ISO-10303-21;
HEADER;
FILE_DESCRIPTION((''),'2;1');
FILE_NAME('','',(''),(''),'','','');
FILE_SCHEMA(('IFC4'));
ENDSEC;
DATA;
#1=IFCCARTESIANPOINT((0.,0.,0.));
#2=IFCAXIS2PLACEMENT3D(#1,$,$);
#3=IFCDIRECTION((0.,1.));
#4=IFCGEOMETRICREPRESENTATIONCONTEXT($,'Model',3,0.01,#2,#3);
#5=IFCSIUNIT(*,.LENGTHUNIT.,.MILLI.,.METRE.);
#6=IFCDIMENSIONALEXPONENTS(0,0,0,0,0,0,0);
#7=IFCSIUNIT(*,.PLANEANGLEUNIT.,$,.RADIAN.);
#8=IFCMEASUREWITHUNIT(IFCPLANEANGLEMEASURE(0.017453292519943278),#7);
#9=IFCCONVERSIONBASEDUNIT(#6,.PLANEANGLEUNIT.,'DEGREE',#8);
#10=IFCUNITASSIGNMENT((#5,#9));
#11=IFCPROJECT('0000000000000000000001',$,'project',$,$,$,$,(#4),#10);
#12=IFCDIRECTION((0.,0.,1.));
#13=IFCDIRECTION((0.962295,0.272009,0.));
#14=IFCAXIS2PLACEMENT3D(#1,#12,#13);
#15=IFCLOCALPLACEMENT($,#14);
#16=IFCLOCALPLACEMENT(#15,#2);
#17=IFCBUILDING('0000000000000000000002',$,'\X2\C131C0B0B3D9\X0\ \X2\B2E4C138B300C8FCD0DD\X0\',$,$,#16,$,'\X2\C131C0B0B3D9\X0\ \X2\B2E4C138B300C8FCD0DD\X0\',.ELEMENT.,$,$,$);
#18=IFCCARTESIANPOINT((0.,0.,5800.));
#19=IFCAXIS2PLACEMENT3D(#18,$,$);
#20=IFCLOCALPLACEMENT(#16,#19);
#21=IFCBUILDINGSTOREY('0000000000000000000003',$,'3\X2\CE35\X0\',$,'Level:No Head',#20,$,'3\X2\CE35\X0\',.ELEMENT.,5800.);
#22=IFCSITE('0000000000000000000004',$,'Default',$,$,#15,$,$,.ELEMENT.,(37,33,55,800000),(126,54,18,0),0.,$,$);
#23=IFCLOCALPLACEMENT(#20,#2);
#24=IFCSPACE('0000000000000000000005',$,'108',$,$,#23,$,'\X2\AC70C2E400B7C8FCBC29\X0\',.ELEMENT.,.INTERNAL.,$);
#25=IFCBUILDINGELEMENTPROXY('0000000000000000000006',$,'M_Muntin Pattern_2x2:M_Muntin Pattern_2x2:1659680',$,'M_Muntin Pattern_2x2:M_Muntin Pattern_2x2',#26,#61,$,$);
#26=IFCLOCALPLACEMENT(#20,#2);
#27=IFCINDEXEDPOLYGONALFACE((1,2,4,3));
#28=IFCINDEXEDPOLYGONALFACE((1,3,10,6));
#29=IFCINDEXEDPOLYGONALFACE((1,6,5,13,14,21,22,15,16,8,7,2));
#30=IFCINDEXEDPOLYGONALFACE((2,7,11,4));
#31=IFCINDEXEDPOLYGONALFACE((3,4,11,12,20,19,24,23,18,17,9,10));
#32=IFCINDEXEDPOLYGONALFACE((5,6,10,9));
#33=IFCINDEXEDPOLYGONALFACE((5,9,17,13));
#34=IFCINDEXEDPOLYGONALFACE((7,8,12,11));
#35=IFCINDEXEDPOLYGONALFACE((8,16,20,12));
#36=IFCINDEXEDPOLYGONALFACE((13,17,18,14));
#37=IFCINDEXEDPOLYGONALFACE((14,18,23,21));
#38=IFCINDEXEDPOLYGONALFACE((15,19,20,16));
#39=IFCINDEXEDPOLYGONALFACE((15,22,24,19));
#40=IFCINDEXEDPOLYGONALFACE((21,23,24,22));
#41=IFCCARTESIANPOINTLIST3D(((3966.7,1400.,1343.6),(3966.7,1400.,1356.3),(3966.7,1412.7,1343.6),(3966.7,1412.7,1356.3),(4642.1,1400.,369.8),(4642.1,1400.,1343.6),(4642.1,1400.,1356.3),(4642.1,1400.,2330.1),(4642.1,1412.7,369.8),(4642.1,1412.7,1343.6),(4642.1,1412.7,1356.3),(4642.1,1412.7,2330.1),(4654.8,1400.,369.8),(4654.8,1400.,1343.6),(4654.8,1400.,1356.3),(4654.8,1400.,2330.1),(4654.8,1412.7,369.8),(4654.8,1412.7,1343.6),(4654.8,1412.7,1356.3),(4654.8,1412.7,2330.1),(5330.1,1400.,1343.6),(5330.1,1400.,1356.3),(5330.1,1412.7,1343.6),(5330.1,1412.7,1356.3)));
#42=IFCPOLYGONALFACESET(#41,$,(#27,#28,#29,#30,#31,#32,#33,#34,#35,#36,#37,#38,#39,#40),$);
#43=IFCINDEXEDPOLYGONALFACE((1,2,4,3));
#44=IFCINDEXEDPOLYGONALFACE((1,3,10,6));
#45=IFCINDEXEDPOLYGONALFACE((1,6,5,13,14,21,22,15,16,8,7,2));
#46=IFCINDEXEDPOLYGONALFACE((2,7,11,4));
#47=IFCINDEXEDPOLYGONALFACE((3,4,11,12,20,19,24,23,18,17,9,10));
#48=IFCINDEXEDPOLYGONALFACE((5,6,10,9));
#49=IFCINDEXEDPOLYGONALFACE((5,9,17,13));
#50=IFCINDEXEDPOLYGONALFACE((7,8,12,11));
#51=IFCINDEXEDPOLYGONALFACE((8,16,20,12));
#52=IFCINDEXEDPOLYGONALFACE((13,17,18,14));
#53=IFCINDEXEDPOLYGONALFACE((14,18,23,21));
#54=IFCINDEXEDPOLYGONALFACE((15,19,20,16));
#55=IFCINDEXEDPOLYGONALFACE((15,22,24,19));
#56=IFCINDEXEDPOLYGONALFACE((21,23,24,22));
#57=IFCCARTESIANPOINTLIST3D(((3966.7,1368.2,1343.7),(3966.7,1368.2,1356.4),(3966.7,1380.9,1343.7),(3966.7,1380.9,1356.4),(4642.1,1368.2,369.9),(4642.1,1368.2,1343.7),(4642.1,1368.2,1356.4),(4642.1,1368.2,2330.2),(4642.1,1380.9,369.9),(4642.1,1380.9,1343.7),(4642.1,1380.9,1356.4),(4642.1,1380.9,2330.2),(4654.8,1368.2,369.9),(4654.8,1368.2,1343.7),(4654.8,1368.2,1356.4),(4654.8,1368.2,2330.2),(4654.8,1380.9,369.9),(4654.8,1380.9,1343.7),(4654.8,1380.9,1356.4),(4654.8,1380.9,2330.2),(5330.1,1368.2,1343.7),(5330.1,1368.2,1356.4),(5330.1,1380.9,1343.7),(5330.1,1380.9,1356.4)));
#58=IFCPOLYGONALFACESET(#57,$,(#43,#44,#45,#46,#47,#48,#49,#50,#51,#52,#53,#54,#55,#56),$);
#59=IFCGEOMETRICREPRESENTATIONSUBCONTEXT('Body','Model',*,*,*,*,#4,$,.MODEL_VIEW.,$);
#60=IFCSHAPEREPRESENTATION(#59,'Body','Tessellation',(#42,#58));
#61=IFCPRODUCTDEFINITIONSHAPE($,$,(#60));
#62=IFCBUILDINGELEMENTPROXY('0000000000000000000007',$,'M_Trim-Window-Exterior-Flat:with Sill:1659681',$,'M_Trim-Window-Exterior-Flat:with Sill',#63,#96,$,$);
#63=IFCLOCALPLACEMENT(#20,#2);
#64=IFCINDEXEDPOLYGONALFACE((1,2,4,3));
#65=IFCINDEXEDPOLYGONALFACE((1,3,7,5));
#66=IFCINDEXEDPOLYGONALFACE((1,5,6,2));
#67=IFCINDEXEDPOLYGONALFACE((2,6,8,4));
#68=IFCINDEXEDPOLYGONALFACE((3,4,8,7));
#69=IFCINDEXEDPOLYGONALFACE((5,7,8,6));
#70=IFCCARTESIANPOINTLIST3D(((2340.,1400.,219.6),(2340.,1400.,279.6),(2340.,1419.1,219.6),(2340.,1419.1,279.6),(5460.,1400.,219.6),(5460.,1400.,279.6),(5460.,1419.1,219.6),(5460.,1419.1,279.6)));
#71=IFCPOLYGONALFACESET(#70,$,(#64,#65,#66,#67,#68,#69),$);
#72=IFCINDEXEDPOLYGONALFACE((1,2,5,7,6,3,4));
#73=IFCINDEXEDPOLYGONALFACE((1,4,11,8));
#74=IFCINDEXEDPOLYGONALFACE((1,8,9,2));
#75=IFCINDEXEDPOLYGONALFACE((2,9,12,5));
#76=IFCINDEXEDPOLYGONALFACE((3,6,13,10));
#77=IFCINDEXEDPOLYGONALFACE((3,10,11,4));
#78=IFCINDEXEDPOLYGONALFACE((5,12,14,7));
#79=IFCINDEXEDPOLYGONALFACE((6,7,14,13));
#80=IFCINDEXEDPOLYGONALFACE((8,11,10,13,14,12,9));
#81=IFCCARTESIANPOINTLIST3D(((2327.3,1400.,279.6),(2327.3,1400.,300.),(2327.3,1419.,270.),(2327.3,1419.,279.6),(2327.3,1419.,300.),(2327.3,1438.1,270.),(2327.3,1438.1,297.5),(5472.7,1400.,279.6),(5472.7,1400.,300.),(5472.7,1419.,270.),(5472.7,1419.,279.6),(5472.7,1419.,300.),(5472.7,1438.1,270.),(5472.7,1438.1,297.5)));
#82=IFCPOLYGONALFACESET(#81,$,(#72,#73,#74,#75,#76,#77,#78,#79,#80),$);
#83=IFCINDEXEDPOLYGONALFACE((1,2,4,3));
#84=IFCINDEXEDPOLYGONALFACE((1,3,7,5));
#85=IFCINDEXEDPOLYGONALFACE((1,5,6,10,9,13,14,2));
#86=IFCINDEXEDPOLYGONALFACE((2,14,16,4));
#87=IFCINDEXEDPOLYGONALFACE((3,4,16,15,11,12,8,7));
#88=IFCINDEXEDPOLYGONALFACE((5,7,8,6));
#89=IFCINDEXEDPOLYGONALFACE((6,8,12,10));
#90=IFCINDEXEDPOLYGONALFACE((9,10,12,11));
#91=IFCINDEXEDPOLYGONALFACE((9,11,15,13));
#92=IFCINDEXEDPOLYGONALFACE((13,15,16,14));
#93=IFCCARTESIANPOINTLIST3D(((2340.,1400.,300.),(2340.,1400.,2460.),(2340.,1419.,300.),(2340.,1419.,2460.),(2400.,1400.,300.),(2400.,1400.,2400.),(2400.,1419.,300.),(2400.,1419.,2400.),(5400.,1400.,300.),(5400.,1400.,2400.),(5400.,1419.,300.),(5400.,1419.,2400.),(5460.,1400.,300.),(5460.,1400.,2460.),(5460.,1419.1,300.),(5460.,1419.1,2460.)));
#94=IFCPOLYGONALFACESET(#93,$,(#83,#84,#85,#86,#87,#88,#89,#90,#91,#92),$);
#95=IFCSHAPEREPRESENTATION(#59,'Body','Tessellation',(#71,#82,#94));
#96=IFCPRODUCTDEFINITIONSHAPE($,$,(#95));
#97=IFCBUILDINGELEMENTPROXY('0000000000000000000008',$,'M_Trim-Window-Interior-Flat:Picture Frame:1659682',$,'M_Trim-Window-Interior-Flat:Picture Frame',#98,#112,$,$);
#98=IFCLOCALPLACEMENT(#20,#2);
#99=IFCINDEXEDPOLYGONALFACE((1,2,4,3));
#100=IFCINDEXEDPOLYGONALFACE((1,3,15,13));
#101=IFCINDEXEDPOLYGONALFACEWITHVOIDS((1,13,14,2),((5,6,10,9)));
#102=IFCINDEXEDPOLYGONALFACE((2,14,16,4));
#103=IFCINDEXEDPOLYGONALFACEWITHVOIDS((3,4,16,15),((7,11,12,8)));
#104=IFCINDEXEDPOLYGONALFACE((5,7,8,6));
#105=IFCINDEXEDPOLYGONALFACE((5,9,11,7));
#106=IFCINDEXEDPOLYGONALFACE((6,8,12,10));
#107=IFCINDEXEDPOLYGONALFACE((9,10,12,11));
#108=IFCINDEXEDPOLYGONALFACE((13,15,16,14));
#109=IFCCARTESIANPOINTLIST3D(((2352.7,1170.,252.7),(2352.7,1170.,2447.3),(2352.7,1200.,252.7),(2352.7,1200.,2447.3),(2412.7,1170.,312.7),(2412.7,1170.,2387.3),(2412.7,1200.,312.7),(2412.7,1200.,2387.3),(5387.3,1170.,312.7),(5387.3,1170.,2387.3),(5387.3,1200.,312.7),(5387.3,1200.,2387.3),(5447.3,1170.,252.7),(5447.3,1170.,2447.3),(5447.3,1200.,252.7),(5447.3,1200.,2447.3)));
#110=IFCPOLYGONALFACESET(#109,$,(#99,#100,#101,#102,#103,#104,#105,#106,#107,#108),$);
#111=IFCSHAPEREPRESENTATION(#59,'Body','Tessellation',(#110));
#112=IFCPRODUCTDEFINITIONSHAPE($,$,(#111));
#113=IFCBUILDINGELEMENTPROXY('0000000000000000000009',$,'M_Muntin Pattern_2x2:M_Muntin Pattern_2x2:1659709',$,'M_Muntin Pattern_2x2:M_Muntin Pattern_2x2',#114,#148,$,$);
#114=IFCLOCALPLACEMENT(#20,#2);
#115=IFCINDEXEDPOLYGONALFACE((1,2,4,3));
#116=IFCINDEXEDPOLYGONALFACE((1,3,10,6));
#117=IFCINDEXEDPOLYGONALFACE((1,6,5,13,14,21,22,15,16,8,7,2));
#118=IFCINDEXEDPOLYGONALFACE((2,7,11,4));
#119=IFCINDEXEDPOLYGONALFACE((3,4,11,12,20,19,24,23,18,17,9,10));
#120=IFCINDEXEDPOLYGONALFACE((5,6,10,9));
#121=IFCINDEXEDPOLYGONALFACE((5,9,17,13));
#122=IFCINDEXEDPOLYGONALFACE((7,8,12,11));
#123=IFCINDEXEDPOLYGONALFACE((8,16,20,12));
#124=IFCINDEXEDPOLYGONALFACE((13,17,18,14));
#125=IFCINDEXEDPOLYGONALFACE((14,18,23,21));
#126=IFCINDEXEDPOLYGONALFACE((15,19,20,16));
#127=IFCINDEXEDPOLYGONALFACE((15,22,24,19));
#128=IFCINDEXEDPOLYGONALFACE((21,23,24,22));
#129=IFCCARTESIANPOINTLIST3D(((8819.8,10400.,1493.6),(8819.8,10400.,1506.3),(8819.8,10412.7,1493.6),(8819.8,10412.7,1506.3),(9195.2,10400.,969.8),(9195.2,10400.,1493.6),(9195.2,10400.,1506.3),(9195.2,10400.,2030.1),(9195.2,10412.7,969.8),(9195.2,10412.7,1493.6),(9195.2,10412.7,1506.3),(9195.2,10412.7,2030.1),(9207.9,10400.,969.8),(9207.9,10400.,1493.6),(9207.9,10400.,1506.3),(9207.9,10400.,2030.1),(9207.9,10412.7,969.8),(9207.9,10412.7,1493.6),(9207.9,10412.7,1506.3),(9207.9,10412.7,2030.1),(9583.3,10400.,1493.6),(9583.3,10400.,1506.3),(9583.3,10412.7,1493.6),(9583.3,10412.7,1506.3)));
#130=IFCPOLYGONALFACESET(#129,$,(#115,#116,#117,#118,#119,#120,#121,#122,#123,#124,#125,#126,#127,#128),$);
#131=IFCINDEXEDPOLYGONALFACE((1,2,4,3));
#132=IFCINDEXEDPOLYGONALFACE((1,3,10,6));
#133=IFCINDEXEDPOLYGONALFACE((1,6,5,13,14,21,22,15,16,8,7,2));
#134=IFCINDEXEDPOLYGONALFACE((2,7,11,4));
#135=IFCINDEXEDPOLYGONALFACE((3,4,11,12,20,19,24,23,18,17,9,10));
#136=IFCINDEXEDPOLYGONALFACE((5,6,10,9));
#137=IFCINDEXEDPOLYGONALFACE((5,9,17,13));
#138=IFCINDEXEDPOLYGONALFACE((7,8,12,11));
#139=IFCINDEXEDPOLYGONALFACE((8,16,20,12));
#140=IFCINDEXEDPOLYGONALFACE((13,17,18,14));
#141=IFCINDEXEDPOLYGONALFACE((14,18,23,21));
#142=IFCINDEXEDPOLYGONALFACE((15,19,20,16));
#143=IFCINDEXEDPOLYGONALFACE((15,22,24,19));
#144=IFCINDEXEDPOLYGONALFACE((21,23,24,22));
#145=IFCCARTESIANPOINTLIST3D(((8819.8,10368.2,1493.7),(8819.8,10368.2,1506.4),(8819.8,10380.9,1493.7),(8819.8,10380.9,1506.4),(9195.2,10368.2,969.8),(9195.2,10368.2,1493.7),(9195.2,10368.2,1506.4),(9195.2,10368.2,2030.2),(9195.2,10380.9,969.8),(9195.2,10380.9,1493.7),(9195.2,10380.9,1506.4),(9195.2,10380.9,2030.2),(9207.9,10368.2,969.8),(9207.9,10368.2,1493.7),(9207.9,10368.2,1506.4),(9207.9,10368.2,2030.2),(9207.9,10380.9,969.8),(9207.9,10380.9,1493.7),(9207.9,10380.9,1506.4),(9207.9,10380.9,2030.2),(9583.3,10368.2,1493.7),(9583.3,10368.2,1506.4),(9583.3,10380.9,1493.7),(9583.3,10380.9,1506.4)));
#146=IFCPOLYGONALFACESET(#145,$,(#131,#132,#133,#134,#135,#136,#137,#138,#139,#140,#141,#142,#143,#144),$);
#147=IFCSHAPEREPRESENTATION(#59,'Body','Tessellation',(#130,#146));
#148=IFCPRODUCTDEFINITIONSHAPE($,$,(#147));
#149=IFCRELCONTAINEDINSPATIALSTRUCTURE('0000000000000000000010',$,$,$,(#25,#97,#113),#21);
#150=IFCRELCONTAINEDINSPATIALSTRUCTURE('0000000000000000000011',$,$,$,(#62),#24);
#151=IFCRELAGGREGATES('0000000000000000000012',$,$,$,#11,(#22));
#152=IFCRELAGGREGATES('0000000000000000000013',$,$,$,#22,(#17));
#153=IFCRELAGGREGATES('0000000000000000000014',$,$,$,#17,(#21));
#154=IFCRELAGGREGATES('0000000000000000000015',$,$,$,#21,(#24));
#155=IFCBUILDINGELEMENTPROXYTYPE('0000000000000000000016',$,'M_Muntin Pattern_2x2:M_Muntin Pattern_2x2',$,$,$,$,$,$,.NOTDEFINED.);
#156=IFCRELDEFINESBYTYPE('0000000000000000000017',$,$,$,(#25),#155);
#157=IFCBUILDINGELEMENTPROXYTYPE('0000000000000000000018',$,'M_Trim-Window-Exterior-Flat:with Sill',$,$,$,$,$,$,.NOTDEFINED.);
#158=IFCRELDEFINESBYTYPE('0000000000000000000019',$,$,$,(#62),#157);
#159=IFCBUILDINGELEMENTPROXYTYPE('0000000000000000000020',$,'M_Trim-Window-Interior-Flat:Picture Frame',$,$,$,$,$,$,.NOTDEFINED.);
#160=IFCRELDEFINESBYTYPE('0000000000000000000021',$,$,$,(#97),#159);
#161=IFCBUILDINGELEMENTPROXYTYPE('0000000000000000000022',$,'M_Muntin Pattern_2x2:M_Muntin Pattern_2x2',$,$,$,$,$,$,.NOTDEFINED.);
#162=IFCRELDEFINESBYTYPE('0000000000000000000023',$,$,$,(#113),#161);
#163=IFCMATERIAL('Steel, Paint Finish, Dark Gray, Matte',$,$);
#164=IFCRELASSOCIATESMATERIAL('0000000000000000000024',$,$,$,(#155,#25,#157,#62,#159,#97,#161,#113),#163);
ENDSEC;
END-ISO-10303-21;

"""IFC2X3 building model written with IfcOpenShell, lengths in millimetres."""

from ifc_helpers import new_model, entity, si_unit, converted_unit, direction, frame, frame_2d, origin, place, context, subcontext, project, spatial, polyline, rectangle, outline, extrude, source, transform, mapped, material, type_object, type_shapes, element, save


model = new_model("IFC2X3")

# Units and contexts
model_context = context("Model", 3, precision=0.01, world=origin(), true_north=direction((0.0, 1.0)))
body_context = subcontext(model_context, "Body", "Model", "MODEL_VIEW")
ifc_project = project(units=[si_unit("LENGTHUNIT", "METRE", prefix="MILLI"), converted_unit("PLANEANGLEUNIT", "DEGREE", entity("IfcPlaneAngleMeasure", 0.017453292519943278), si_unit("PLANEANGLEUNIT", "RADIAN"), dimensions=[0, 0, 0, 0, 0, 0, 0])], contexts=[model_context])

# Site, building, storey
site_placement = place(None, frame((0.0, 0.0, 0.0), z_axis=(0.0, 0.0, 1.0), x_axis=(0.962295, 0.272009, 0.0)))
site = spatial("IfcSite", under=ifc_project, at=site_placement, Name="Default", CompositionType="ELEMENT", RefLatitude=(37, 33, 55, 800000), RefLongitude=(126, 54, 18, 0), RefElevation=0.0)
building_placement = place(site_placement, origin())
building = spatial("IfcBuilding", under=site, at=building_placement, Name="성산동 다세대주택", LongName="성산동 다세대주택", CompositionType="ELEMENT")
storey_placement = place(building_placement, frame((0.0, 0.0, 5800.0)))
storey = spatial("IfcBuildingStorey", under=building, at=storey_placement, Name="3층", ObjectType="Level:No Head", LongName="3층", CompositionType="ELEMENT", Elevation=5800.0)

# Shared definitions
space_1_placement = place(storey_placement, origin())
space_1 = spatial("IfcSpace", under=storey, at=space_1_placement, Name="108", LongName="거실·주방", CompositionType="ELEMENT", InteriorOrExteriorSpace="INTERNAL")

# Building element proxies
ifc_material_1 = material(Name="Steel, Paint Finish, Dark Gray, Matte")
building_element_proxy_type_1 = type_object("IfcBuildingElementProxyType", Name="M_Muntin Pattern_2x2:M_Muntin Pattern_2x2", PredefinedType="NOTDEFINED", material=ifc_material_1)
shared_shape_1 = source(origin(), body_context, "Body", "SweptSolid", [
    extrude(outline(polyline([(6.4, -6.4), (980.1, -6.4), (980.1, 6.3), (6.4, 6.3), (6.4, 681.7), (-6.3, 681.7), (-6.3, 6.3), (-980.2, 6.3), (-980.2, -6.4), (-6.3, -6.4), (-6.3, -681.7), (6.4, -681.7), (6.4, -6.4)])), frame((0.0, -22.2, 980.1), z_axis=(0.0, 1.0, 0.0), x_axis=(0.0, 0.0, 1.0)), (0.0, 0.0, 1.0), 12.7),
    extrude(outline(polyline([(6.4, -6.4), (980.2, -6.4), (980.2, 6.3), (6.4, 6.3), (6.4, 681.7), (-6.3, 681.7), (-6.3, 6.3), (-980.2, 6.3), (-980.2, -6.4), (-6.3, -6.4), (-6.3, -681.7), (6.4, -681.7), (6.4, -6.4)])), frame((0.0, 9.5, 980.2), z_axis=(0.0, 1.0, 0.0), x_axis=(0.0, 0.0, 1.0)), (0.0, 0.0, 1.0), 12.7),
])
type_shapes(building_element_proxy_type_1, [shared_shape_1])
proxy_1_placement = place(storey_placement, frame((4648.4, 1390.5, 369.9), z_axis=(0.0, 0.0, 1.0), x_axis=(-1.0, 0.0, 0.0)))
element("IfcBuildingElementProxy", 1, at=proxy_1_placement, inside=storey, type_object=building_element_proxy_type_1, material=ifc_material_1, Name="M_Muntin Pattern_2x2:M_Muntin Pattern_2x2:1659680", ObjectType="M_Muntin Pattern_2x2:M_Muntin Pattern_2x2", context=body_context, shape_type="MappedRepresentation", body=[
    mapped(shared_shape_1, transform((0.0, 0.0, 0.0), scale=1.0)),
])
building_element_proxy_type_2 = type_object("IfcBuildingElementProxyType", Name="M_Trim-Window-Exterior-Flat:with Sill", PredefinedType="NOTDEFINED", material=ifc_material_1)
shared_shape_2 = source(origin(), body_context, "Body", "SweptSolid", [
    extrude(rectangle(XDim=3120.0, YDim=60.0, at=frame_2d((0.0, 0.0), x_axis=(1.0, 0.0))), frame((0.0, -2150.4, 0.0), z_axis=(0.0, 0.0, 1.0), x_axis=(-1.0, 0.0, 0.0)), (0.0, 0.0, 1.0), 19.0),
    extrude(outline(polyline([(-19.0, -15.2), (0.0, -15.2), (0.0, -5.7), (19.0, -5.7), (19.0, 14.8), (0.0, 14.8), (-19.0, 12.3), (-19.0, -15.2)])), frame((-1572.7, -2114.8, 19.0), z_axis=(1.0, 0.0, 0.0), x_axis=(0.0, 0.0, -1.0)), (0.0, 0.0, 1.0), 3145.4),
    extrude(outline(polyline([(-1095.0, -1560.0), (1065.0, -1560.0), (1065.0, -1500.0), (-1035.0, -1500.0), (-1035.0, 1500.0), (1065.0, 1500.0), (1065.0, 1560.0), (-1095.0, 1560.0), (-1095.0, -1560.0)])), frame((0.0, -1035.0, 0.0), z_axis=(0.0, 0.0, 1.0), x_axis=(0.0, -1.0, 0.0)), (0.0, 0.0, 1.0), 19.0),
])
type_shapes(building_element_proxy_type_2, [shared_shape_2])
proxy_2_placement = place(space_1_placement, frame((3900.0, 1400.0, 2400.0), z_axis=(0.0, 1.0, 0.0), x_axis=(-1.0, 0.0, 0.0)))
element("IfcBuildingElementProxy", 2, at=proxy_2_placement, inside=space_1, type_object=building_element_proxy_type_2, material=ifc_material_1, Name="M_Trim-Window-Exterior-Flat:with Sill:1659681", ObjectType="M_Trim-Window-Exterior-Flat:with Sill", context=body_context, shape_type="MappedRepresentation", body=[
    mapped(shared_shape_2, transform((0.0, 0.0, 0.0), scale=1.0)),
])
building_element_proxy_type_3 = type_object("IfcBuildingElementProxyType", Name="M_Trim-Window-Interior-Flat:Picture Frame", PredefinedType="NOTDEFINED", material=ifc_material_1)
shared_shape_3 = source(origin(), body_context, "Body", "SweptSolid", [
    extrude(outline(polyline([(-1547.3, -1097.3), (1547.3, -1097.3), (1547.3, 1097.3), (-1547.3, 1097.3), (-1547.3, -1097.3)]), holes=[polyline([(-1487.3, -1037.3), (-1487.3, 1037.3), (1487.3, 1037.3), (1487.3, -1037.3), (-1487.3, -1037.3)])]), frame((0.0, -1050.0, 0.0), z_axis=(0.0, 0.0, 1.0), x_axis=(-1.0, 0.0, 0.0)), (0.0, 0.0, 1.0), 30.0),
])
type_shapes(building_element_proxy_type_3, [shared_shape_3])
proxy_3_placement = place(storey_placement, frame((3900.0, 1200.0, 2400.0), z_axis=(0.0, -1.0, 0.0), x_axis=(1.0, 0.0, 0.0)))
element("IfcBuildingElementProxy", 3, at=proxy_3_placement, inside=storey, type_object=building_element_proxy_type_3, material=ifc_material_1, Name="M_Trim-Window-Interior-Flat:Picture Frame:1659682", ObjectType="M_Trim-Window-Interior-Flat:Picture Frame", context=body_context, shape_type="MappedRepresentation", body=[
    mapped(shared_shape_3, transform((0.0, 0.0, 0.0), scale=1.0)),
])
building_element_proxy_type_4 = type_object("IfcBuildingElementProxyType", Name="M_Muntin Pattern_2x2:M_Muntin Pattern_2x2", PredefinedType="NOTDEFINED", material=ifc_material_1)
shared_shape_4 = source(origin(), body_context, "Body", "SweptSolid", [
    extrude(outline(polyline([(6.4, -6.4), (530.1, -6.4), (530.1, 6.3), (6.4, 6.3), (6.4, 381.7), (-6.3, 381.7), (-6.3, 6.3), (-530.2, 6.3), (-530.2, -6.4), (-6.3, -6.4), (-6.3, -381.7), (6.4, -381.7), (6.4, -6.4)])), frame((0.0, 9.5, 530.1), z_axis=(0.0, 1.0, 0.0), x_axis=(0.0, 0.0, 1.0)), (0.0, 0.0, 1.0), 12.7),
    extrude(outline(polyline([(6.4, -6.4), (530.2, -6.4), (530.2, 6.3), (6.4, 6.3), (6.4, 381.7), (-6.3, 381.7), (-6.3, 6.3), (-530.2, 6.3), (-530.2, -6.4), (-6.3, -6.4), (-6.3, -381.7), (6.4, -381.7), (6.4, -6.4)])), frame((0.0, -22.2, 530.2), z_axis=(0.0, 1.0, 0.0), x_axis=(0.0, 0.0, 1.0)), (0.0, 0.0, 1.0), 12.7),
])
type_shapes(building_element_proxy_type_4, [shared_shape_4])
proxy_4_placement = place(storey_placement, frame((9201.6, 10390.5, 969.8)))
element("IfcBuildingElementProxy", 4, at=proxy_4_placement, inside=storey, type_object=building_element_proxy_type_4, material=ifc_material_1, Name="M_Muntin Pattern_2x2:M_Muntin Pattern_2x2:1659709", ObjectType="M_Muntin Pattern_2x2:M_Muntin Pattern_2x2", context=body_context, shape_type="MappedRepresentation", body=[
    mapped(shared_shape_4, transform((0.0, 0.0, 0.0), scale=1.0)),
])

save(model, "model.ifc")
